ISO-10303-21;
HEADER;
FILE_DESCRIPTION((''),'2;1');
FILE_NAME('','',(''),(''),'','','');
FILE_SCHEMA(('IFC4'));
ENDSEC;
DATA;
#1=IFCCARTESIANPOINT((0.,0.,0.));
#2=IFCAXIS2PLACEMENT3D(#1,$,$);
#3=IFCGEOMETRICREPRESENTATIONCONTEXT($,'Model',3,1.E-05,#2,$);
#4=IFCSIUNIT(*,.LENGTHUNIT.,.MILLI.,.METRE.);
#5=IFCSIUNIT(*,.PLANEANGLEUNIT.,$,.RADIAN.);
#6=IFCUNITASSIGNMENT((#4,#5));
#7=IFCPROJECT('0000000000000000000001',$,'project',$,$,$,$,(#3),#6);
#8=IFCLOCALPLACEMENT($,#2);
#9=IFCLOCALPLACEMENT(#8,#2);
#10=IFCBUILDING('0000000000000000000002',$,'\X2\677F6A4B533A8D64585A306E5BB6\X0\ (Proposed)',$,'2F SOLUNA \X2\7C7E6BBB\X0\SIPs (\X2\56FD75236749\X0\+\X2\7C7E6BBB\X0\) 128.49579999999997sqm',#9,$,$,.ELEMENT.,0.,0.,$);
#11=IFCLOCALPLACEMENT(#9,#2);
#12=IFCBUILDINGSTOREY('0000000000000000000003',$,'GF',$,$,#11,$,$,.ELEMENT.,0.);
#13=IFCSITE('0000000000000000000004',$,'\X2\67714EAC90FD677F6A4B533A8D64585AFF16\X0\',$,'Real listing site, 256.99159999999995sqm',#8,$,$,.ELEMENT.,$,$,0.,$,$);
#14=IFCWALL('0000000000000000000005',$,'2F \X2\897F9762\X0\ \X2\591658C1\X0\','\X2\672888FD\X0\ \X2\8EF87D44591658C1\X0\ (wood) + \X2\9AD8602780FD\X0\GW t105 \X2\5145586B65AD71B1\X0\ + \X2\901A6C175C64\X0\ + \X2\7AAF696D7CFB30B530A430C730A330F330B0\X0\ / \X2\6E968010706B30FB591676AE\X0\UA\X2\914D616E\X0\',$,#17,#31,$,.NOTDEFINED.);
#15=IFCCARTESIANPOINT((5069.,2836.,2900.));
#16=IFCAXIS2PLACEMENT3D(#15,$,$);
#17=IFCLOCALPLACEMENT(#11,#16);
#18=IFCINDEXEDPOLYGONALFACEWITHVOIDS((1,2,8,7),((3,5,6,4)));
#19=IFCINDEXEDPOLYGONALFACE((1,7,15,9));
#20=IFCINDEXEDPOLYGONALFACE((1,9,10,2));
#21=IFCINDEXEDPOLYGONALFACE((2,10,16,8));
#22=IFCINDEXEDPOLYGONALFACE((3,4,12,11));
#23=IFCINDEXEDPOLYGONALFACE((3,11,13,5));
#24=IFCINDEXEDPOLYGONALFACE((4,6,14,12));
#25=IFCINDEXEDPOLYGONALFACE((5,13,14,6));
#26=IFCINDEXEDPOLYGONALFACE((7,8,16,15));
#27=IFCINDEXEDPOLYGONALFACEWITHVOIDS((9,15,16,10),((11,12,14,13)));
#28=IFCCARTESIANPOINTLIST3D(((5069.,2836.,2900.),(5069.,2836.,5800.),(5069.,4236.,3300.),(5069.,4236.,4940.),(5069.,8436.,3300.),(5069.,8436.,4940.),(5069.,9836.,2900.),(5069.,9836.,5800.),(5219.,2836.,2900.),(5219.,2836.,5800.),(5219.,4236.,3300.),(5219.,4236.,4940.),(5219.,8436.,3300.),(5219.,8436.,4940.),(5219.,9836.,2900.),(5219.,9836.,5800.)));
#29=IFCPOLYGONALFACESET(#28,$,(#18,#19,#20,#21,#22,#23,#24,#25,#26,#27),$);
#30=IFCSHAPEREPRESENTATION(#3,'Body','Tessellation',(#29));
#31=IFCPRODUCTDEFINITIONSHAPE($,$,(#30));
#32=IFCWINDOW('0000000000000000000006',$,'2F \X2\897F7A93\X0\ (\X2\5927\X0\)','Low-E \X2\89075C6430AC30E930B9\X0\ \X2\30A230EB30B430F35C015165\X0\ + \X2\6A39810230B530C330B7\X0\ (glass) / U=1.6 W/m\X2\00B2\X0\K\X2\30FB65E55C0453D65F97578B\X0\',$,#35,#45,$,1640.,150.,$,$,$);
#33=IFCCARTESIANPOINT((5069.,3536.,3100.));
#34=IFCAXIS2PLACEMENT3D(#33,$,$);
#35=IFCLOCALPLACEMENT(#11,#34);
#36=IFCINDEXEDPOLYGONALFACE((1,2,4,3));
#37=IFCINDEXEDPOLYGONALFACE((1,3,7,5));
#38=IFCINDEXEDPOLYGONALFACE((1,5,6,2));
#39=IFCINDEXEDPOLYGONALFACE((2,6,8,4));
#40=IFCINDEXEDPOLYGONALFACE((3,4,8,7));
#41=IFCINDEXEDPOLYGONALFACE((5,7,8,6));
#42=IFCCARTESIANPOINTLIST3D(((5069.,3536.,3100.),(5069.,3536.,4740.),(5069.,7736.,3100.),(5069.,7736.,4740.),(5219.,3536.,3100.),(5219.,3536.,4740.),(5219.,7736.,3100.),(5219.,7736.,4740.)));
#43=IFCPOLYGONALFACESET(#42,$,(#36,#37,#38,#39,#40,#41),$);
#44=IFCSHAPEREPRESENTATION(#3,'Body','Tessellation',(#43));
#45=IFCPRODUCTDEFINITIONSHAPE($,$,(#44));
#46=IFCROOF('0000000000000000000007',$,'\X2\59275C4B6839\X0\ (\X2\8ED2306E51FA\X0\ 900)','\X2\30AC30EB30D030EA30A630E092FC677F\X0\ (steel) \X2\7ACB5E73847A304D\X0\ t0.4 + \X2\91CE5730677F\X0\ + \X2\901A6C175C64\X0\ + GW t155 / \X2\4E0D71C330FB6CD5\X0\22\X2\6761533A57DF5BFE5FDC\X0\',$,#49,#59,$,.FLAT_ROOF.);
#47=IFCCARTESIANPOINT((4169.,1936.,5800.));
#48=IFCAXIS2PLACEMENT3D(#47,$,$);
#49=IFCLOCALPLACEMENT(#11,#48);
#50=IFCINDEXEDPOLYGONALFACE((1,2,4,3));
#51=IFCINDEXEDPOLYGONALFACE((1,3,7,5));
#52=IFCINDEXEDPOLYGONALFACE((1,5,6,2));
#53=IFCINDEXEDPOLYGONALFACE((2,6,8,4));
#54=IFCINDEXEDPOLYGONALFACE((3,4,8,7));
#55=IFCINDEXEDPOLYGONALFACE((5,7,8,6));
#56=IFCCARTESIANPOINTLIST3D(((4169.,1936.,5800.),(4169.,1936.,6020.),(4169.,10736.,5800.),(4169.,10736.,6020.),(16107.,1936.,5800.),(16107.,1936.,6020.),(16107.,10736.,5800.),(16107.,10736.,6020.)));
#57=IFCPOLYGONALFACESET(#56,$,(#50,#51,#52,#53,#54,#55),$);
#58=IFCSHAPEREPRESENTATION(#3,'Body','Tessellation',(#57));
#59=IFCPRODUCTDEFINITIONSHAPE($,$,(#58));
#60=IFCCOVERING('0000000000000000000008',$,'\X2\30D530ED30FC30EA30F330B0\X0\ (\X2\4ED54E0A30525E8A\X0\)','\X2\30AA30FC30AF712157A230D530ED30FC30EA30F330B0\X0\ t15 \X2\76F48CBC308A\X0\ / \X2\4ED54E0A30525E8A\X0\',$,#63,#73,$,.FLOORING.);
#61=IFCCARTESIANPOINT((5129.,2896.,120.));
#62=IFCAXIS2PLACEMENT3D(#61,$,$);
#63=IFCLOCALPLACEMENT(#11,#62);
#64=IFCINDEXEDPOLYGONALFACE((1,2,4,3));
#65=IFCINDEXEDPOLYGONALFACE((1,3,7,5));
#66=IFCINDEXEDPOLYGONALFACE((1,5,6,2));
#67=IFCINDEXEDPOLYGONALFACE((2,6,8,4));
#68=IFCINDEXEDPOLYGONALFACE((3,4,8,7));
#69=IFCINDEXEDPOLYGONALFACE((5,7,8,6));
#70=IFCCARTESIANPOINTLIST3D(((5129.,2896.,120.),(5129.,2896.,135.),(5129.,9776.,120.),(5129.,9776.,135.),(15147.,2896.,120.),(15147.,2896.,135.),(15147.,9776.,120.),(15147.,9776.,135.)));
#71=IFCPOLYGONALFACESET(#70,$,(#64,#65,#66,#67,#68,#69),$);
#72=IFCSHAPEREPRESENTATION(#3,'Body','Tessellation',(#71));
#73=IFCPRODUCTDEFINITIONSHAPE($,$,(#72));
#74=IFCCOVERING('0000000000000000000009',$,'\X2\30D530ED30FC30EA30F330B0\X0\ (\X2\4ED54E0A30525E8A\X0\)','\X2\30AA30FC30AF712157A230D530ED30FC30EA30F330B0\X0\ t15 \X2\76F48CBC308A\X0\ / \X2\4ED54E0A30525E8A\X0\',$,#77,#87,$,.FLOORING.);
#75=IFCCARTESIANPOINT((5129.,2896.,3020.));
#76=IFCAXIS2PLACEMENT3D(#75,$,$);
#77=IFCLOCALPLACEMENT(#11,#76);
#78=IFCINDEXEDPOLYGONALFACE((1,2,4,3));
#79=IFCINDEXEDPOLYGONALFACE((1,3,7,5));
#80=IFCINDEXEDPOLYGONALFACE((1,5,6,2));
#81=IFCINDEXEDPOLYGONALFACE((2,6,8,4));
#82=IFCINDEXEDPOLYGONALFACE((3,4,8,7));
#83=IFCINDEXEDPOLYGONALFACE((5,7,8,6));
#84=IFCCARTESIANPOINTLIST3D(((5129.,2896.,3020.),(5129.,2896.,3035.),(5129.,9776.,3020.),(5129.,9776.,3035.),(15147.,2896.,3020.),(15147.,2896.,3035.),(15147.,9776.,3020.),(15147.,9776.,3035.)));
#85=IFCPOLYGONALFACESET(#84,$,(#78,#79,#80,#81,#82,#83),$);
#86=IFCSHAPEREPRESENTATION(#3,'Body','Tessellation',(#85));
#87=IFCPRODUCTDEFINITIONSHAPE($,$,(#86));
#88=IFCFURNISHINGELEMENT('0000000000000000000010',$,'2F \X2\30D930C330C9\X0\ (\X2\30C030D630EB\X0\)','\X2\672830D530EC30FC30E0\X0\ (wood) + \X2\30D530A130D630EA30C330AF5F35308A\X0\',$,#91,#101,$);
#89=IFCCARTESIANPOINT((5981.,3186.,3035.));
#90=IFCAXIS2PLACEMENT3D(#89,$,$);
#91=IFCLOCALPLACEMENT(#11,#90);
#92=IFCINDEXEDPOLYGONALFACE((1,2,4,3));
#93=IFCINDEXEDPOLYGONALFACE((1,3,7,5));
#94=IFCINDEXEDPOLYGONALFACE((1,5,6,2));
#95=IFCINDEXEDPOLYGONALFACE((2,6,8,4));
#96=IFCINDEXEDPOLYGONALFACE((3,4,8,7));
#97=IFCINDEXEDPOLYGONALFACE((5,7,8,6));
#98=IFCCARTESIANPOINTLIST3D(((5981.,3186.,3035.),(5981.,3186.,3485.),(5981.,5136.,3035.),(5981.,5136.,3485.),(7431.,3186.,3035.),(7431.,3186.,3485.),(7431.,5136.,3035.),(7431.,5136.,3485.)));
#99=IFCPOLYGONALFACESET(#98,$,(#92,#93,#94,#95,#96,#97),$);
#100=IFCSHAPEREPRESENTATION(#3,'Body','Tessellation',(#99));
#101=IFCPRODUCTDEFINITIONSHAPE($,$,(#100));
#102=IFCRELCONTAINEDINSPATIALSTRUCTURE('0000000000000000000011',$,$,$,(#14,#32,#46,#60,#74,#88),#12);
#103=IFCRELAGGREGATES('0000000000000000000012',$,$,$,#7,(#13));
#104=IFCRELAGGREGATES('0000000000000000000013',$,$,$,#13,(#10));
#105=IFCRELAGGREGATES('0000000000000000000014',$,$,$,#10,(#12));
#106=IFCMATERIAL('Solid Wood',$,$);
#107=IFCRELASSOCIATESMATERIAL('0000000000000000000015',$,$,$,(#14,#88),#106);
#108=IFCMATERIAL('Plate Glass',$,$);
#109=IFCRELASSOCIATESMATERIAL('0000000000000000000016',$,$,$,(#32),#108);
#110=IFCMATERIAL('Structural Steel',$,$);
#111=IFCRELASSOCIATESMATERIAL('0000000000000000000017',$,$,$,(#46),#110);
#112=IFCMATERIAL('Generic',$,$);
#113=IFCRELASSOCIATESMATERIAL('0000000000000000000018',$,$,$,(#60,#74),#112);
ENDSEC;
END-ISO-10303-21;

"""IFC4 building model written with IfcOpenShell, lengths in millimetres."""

from ifc_helpers import new_model, si_unit, frame, frame_2d, origin, place, context, project, spatial, rectangle, extrude, material, element, fill, save


model = new_model("IFC4")

# Units and contexts
model_context = context("Model", 3, precision=1e-05, world=origin())
ifc_project = project(units=[si_unit("LENGTHUNIT", "METRE", prefix="MILLI"), si_unit("PLANEANGLEUNIT", "RADIAN")], contexts=[model_context])

# Site, building, storey
site_placement = place(None, origin())
site = spatial("IfcSite", under=ifc_project, at=site_placement, Name="東京都板橋区赤塚６", ObjectType="Real listing site, 256.99159999999995sqm", CompositionType="ELEMENT", RefElevation=0.0)
building_placement = place(site_placement, origin())
building = spatial("IfcBuilding", under=site, at=building_placement, Name="板橋区赤塚の家 (Proposed)", ObjectType="2F SOLUNA 籾殻SIPs (国産杉+籾殻) 128.49579999999997sqm", CompositionType="ELEMENT", ElevationOfRefHeight=0.0, ElevationOfTerrain=0.0)
storey_placement = place(building_placement, origin())
storey = spatial("IfcBuildingStorey", under=building, at=storey_placement, Name="GF", CompositionType="ELEMENT", Elevation=0.0)

# Shared definitions
ifc_material_1 = material(Name="Solid Wood")

# Shared definitions
ifc_material_2 = material(Name="Plate Glass")

# Wall, opening, window
wall_1_placement = place(storey_placement, frame((5069.0, 2836.0, 2900.0)))
wall_1 = element("IfcWall", 1, at=wall_1_placement, inside=storey, material=ifc_material_1, Name="2F 西面 外壁", Description="木製 軸組外壁 (wood) + 高性能GW t105 充填断熱 + 通気層 + 窯業系サイディング / 準耐火・外皮UA配慮", PredefinedType="NOTDEFINED", context=model_context, shape_type="SweptSolid", body=[
    extrude(rectangle(XDim=150.0, YDim=7000.0, at=frame_2d((75.0, 3500.0))), frame((5069.0, 2836.0, 2900.0)), (0.0, 0.0, 1.0), 2900.0),
])
opening_1_placement = place(storey_placement, frame((5069.0, 3536.0, 3100.0)))
opening_1 = element("IfcOpeningElement", 2, at=opening_1_placement, cuts=wall_1, PredefinedType="NOTDEFINED", context=model_context, shape_type="SweptSolid", body=[
    extrude(rectangle(XDim=150.0, YDim=4200.0, at=frame_2d((75.0, 2100.0))), frame((5069.0, 3536.0, 3100.0)), (0.0, 0.0, 1.0), 1640.0),
])
window_1_placement = place(storey_placement, frame((5069.0, 3536.0, 3100.0)))
window_1 = element("IfcWindow", 3, at=window_1_placement, inside=storey, material=ifc_material_2, Name="2F 西窓 (大)", Description="Low-E 複層ガラス アルゴン封入 + 樹脂サッシ (glass) / U=1.6 W/m²K・日射取得型", OverallHeight=1640.0, OverallWidth=150.0, context=model_context, shape_type="SweptSolid", body=[
    extrude(rectangle(XDim=150.0, YDim=4200.0, at=frame_2d((75.0, 2100.0))), frame((5069.0, 3536.0, 3100.0)), (0.0, 0.0, 1.0), 1640.0),
])
fill(opening_1, window_1)

# Roof
ifc_material_3 = material(Name="Structural Steel")
roof_placement = place(storey_placement, frame((4169.0, 1936.0, 5800.0)))
element("IfcRoof", 4, at=roof_placement, inside=storey, material=ifc_material_3, Name="大屋根 (軒の出 900)", Description="ガルバリウム鋼板 (steel) 立平葺き t0.4 + 野地板 + 通気層 + GW t155 / 不燃・法22条区域対応", PredefinedType="FLAT_ROOF", context=model_context, shape_type="SweptSolid", body=[
    extrude(rectangle(XDim=11938.0, YDim=8800.0, at=frame_2d((5969.0, 4400.0))), frame((4169.0, 1936.0, 5800.0)), (0.0, 0.0, 1.0), 220.0),
])

# Coverings
ifc_material_4 = material(Name="Generic")
covering_1_placement = place(storey_placement, frame((5129.0, 2896.0, 120.0)))
element("IfcCovering", 5, at=covering_1_placement, inside=storey, material=ifc_material_4, Name="フローリング (仕上げ床)", Description="オーク無垢フローリング t15 直貼り / 仕上げ床", PredefinedType="FLOORING", context=model_context, shape_type="SweptSolid", body=[
    extrude(rectangle(XDim=10018.0, YDim=6880.0, at=frame_2d((5009.0, 3440.0))), frame((5129.0, 2896.0, 120.0)), (0.0, 0.0, 1.0), 15.0),
])
covering_2_placement = place(storey_placement, frame((5129.0, 2896.0, 3020.0)))
element("IfcCovering", 6, at=covering_2_placement, inside=storey, material=ifc_material_4, Name="フローリング (仕上げ床)", Description="オーク無垢フローリング t15 直貼り / 仕上げ床", PredefinedType="FLOORING", context=model_context, shape_type="SweptSolid", body=[
    extrude(rectangle(XDim=10018.0, YDim=6880.0, at=frame_2d((5009.0, 3440.0))), frame((5129.0, 2896.0, 3020.0)), (0.0, 0.0, 1.0), 15.0),
])

# Furnishing element
furnishing_placement = place(storey_placement, frame((5981.0, 3186.0, 3035.0)))
element("IfcFurnishingElement", 7, at=furnishing_placement, inside=storey, material=ifc_material_1, Name="2F ベッド (ダブル)", Description="木フレーム (wood) + ファブリック張り", context=model_context, shape_type="SweptSolid", body=[
    extrude(rectangle(XDim=1450.0, YDim=1950.0, at=frame_2d((725.0, 975.0))), frame((5981.0, 3186.0, 3035.0)), (0.0, 0.0, 1.0), 450.0),
])

save(model, "model.ifc")
